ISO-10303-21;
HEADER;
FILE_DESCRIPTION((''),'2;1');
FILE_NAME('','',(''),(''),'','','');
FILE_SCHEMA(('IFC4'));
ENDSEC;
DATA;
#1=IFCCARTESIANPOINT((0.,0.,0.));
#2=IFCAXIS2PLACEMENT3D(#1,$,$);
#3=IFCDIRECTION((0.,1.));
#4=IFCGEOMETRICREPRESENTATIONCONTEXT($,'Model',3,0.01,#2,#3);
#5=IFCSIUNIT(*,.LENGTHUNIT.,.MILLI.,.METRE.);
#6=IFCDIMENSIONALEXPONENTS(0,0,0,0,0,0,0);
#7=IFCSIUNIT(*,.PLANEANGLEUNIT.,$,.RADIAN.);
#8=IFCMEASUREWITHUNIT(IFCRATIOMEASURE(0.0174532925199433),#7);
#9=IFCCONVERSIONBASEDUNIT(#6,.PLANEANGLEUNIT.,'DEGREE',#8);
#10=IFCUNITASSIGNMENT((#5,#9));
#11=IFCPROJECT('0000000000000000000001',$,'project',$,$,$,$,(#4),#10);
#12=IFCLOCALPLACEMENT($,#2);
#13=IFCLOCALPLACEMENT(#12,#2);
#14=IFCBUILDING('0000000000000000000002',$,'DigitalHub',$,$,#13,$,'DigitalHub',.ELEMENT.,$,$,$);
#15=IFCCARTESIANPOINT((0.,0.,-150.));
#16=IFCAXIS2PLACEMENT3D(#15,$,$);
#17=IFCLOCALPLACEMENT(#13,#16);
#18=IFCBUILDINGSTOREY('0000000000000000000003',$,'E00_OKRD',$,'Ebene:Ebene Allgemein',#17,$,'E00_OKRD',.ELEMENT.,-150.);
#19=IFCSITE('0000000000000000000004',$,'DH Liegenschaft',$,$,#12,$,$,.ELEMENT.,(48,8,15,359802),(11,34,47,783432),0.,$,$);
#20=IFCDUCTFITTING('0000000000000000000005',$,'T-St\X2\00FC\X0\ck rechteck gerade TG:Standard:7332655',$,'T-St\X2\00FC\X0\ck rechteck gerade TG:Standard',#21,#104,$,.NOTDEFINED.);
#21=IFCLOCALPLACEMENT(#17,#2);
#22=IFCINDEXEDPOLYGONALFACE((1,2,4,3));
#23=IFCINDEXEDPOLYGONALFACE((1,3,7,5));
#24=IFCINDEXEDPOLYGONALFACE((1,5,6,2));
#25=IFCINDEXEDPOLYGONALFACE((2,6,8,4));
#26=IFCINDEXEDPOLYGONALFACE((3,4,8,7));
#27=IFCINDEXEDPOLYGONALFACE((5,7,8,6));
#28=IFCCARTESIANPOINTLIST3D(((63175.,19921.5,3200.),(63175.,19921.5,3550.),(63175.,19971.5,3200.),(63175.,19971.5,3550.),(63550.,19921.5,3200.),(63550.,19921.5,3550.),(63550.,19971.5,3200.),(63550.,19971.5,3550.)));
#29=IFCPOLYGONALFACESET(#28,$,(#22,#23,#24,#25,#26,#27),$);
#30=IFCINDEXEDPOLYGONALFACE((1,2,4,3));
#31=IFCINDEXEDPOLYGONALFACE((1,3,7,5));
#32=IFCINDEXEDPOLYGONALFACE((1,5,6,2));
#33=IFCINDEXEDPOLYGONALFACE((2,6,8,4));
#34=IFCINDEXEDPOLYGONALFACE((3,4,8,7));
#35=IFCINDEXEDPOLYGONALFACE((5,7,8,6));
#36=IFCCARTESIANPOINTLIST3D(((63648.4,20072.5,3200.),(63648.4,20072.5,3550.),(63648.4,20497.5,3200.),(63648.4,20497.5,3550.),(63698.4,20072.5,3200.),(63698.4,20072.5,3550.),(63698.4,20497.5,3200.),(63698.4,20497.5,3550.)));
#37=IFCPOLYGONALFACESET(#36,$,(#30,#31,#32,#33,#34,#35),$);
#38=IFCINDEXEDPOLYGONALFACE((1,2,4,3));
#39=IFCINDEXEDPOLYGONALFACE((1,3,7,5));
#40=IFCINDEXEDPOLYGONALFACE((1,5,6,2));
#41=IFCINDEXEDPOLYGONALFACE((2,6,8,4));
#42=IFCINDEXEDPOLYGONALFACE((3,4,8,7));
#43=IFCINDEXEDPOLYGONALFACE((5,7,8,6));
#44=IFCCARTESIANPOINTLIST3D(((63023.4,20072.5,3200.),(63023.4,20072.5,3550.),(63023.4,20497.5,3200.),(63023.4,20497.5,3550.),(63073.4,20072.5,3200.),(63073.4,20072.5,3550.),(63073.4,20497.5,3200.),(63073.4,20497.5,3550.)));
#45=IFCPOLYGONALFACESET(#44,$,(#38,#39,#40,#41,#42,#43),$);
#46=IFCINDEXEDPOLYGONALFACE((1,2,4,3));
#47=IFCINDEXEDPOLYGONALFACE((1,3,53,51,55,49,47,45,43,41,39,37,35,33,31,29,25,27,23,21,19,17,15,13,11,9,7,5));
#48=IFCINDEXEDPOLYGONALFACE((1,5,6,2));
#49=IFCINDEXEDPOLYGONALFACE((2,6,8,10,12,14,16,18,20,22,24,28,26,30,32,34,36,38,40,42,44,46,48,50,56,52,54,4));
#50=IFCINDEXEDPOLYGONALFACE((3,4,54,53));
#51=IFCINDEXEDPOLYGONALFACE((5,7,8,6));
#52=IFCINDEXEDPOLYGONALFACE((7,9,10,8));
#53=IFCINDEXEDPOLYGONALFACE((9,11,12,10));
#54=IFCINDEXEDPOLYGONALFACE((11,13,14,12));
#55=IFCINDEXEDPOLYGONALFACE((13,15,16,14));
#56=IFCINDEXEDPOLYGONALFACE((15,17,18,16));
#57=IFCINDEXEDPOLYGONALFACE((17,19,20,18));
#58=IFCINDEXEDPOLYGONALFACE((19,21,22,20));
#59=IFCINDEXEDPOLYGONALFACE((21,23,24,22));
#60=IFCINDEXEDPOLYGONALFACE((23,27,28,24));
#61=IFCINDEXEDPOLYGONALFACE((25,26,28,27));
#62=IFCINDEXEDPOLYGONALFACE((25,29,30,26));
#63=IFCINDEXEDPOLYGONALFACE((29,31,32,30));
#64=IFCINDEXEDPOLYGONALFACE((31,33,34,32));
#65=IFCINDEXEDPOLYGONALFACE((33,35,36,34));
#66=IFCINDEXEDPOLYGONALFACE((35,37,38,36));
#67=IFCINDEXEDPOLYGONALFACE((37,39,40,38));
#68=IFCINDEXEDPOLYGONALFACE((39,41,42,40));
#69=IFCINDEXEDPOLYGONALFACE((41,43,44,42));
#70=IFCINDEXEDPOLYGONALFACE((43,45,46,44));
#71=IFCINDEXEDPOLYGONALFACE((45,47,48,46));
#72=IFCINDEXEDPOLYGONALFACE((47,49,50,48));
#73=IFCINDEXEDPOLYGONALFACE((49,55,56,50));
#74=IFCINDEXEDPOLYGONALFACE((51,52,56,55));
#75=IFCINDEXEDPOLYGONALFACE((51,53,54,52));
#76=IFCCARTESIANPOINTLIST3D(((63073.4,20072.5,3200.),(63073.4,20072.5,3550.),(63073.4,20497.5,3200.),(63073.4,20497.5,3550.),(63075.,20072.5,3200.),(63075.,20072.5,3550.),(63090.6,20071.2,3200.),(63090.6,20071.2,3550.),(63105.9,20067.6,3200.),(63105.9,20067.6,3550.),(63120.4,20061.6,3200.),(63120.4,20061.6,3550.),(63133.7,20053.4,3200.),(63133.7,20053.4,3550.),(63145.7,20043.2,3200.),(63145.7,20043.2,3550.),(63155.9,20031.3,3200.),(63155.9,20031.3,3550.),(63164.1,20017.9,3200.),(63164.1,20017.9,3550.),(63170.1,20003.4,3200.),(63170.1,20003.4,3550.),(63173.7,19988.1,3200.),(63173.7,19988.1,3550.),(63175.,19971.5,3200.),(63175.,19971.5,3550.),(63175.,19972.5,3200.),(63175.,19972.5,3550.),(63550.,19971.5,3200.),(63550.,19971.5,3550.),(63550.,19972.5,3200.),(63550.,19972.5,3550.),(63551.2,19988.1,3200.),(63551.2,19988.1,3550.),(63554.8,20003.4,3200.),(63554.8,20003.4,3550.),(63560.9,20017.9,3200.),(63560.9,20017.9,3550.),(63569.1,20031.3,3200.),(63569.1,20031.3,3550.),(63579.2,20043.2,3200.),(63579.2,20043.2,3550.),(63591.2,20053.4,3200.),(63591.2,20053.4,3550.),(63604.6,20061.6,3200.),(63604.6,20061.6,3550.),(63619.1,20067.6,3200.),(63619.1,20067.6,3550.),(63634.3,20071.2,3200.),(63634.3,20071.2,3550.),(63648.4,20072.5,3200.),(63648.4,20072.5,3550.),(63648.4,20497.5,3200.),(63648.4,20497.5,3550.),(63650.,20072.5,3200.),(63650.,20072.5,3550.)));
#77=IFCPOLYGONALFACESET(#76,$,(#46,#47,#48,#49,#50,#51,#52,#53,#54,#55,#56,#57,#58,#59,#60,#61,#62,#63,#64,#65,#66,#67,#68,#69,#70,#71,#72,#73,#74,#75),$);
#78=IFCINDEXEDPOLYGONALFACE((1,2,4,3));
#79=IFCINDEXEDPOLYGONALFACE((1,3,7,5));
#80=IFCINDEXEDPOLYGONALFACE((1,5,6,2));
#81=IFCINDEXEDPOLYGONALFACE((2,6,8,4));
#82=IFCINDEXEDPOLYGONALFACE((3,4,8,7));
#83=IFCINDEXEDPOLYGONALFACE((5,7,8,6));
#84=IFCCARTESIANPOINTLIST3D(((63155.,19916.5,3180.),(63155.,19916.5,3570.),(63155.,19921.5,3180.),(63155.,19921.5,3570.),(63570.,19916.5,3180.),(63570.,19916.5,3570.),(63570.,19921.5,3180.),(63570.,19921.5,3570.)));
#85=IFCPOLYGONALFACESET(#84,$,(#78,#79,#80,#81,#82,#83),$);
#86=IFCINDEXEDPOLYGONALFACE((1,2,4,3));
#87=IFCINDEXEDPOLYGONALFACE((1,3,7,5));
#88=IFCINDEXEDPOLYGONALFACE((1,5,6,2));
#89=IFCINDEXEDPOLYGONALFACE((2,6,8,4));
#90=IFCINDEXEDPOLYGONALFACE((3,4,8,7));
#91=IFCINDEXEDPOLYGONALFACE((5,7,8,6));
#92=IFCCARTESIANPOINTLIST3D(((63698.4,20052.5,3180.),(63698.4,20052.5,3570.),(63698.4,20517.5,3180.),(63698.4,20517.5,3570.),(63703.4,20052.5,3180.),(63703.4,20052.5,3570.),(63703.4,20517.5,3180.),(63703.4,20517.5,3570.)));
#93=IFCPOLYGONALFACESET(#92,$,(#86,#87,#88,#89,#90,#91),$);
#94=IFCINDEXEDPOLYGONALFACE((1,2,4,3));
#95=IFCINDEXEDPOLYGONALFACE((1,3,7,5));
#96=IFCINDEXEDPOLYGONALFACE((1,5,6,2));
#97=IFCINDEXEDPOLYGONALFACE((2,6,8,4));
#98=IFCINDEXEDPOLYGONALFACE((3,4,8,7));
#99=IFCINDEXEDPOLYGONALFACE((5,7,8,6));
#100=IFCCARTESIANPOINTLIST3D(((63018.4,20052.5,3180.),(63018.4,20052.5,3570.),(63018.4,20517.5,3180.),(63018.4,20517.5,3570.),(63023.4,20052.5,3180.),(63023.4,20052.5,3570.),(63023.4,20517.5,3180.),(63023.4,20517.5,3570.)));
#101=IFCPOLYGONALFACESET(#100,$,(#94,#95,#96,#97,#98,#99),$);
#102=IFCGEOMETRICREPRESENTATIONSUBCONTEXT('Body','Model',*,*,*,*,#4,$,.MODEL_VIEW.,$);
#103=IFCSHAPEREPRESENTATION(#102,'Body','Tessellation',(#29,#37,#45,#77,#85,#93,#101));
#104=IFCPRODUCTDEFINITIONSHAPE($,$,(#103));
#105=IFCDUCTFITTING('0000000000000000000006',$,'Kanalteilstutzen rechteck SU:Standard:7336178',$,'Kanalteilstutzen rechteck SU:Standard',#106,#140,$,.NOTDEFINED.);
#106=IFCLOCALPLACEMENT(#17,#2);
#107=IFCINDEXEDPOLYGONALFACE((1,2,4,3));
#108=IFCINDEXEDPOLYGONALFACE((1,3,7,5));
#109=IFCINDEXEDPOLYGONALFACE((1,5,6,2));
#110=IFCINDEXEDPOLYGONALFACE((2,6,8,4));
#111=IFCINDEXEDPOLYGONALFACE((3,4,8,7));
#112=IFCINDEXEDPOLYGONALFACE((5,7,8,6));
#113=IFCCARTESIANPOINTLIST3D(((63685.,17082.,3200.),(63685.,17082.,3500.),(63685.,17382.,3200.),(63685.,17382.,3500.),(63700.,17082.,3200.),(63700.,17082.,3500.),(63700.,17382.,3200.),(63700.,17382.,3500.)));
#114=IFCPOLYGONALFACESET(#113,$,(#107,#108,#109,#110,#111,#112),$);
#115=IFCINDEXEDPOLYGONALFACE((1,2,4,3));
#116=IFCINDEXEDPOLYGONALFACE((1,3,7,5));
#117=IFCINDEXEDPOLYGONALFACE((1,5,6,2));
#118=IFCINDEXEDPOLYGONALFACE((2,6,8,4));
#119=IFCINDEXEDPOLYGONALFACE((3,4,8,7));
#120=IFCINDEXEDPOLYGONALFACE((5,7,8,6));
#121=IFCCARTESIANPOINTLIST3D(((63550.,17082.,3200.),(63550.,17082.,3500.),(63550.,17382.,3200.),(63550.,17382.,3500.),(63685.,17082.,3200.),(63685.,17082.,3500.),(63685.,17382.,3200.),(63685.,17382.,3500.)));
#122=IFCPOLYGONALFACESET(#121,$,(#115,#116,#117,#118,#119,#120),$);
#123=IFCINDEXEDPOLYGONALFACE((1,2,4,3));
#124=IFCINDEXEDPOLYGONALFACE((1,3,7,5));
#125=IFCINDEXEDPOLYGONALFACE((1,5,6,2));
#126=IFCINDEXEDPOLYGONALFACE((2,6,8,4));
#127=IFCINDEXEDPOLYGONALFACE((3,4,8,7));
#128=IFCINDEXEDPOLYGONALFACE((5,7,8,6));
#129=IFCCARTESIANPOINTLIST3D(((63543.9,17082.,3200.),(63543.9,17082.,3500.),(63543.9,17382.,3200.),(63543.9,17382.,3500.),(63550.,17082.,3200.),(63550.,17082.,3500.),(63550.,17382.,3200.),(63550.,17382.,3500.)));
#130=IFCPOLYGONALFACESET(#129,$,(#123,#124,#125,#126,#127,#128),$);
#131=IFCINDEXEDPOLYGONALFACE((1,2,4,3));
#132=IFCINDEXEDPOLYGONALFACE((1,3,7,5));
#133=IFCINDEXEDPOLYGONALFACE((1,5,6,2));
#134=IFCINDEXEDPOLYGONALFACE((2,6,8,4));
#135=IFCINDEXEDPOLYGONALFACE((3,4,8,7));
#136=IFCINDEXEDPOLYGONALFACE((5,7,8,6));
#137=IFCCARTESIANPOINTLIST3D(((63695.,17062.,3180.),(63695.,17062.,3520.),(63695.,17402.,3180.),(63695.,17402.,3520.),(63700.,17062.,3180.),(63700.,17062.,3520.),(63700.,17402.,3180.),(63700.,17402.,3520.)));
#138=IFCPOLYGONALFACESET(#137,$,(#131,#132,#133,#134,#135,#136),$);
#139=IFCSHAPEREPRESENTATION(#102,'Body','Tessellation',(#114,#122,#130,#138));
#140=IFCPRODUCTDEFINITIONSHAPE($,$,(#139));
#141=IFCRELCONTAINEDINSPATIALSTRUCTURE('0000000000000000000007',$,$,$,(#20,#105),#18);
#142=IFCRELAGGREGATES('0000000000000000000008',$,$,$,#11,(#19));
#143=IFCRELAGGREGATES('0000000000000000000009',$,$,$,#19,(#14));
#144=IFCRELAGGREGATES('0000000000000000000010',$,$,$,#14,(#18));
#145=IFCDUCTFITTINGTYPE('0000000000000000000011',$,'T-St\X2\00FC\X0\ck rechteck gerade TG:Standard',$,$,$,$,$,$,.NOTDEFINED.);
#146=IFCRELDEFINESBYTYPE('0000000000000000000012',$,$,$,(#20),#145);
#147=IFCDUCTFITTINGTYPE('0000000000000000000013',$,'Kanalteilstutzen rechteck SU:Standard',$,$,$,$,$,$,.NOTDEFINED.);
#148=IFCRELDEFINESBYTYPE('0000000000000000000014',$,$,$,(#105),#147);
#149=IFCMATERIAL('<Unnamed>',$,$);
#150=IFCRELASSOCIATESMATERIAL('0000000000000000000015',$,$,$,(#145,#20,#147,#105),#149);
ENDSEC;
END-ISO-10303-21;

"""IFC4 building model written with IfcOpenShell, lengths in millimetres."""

from ifc_helpers import new_model, entity, si_unit, converted_unit, direction, frame, origin, place, context, subcontext, project, spatial, indexed_curve, outline, extrude, source, transform, mapped, material, type_object, type_shapes, element, save


model = new_model("IFC4")

# Units and contexts
model_context = context("Model", 3, precision=0.01, world=origin(), true_north=direction((0.0, 1.0)))
body_context = subcontext(model_context, "Body", "Model", "MODEL_VIEW")
ifc_project = project(units=[si_unit("LENGTHUNIT", "METRE", prefix="MILLI"), converted_unit("PLANEANGLEUNIT", "DEGREE", entity("IfcRatioMeasure", 0.0174532925199433), si_unit("PLANEANGLEUNIT", "RADIAN"), dimensions=[0, 0, 0, 0, 0, 0, 0])], contexts=[model_context])

# Site, building, storey
site_placement = place(None, origin())
site = spatial("IfcSite", under=ifc_project, at=site_placement, Name="DH Liegenschaft", CompositionType="ELEMENT", RefLatitude=(48, 8, 15, 359802), RefLongitude=(11, 34, 47, 783432), RefElevation=0.0)
building_placement = place(site_placement, origin())
building = spatial("IfcBuilding", under=site, at=building_placement, Name="DigitalHub", LongName="DigitalHub", CompositionType="ELEMENT")
storey_placement = place(building_placement, frame((0.0, 0.0, -150.0)))
storey = spatial("IfcBuildingStorey", under=building, at=storey_placement, Name="E00_OKRD", ObjectType="Ebene:Ebene Allgemein", LongName="E00_OKRD", CompositionType="ELEMENT", Elevation=-150.0)

# Shared definitions
ifc_material_1 = material(Name="<Unnamed>")

# Duct fittings
duct_fitting_type_1 = type_object("IfcDuctFittingType", Name="T-Stück rechteck gerade TG:Standard", PredefinedType="NOTDEFINED", material=ifc_material_1)
shared_shape_1 = source(origin(), body_context, "Body", "SweptSolid", [
    extrude(outline(indexed_curve([(-25.0, -187.5), (25.0, -187.5), (25.0, 187.5), (-25.0, 187.5), (-25.0, -187.5)], self_intersect=False)), frame((0.0, -338.5, -175.0), z_axis=(0.0, 0.0, 1.0), x_axis=(0.0, -1.0, 0.0)), (0.0, 0.0, 1.0), 350.0),
    extrude(outline(indexed_curve([(-25.0, -212.5), (25.0, -212.5), (25.0, 212.5), (-25.0, 212.5), (-25.0, -212.5)], self_intersect=False)), frame((310.9, 0.0, -175.0), z_axis=(0.0, 0.0, 1.0), x_axis=(-1.0, 0.0, 0.0)), (0.0, 0.0, 1.0), 350.0),
    extrude(outline(indexed_curve([(-25.0, -212.5), (25.0, -212.5), (25.0, 212.5), (-25.0, 212.5), (-25.0, -212.5)], self_intersect=False)), frame((-314.1, 0.0, -175.0)), (0.0, 0.0, 1.0), 350.0),
    extrude(outline(indexed_curve([(-288.1, -44.8), (-272.5, -46.0), (-257.2, -49.7), (-242.7, -55.7), (-229.4, -63.9), (-217.4, -74.1), (-207.2, -86.0), (-199.0, -99.4), (-193.0, -113.9), (-189.4, -129.2), (-188.1, -144.8), (-188.1, -145.8), (186.9, -145.8), (186.9, -144.8), (188.1, -129.2), (191.8, -113.9), (197.8, -99.4), (206.0, -86.0), (216.1, -74.1), (228.1, -63.9), (241.5, -55.7), (256.0, -49.7), (271.2, -46.0), (286.9, -44.8), (288.5, -44.8), (288.5, 380.2), (-286.5, 380.2), (-286.5, -44.8), (-288.1, -44.8)], self_intersect=False)), frame((-0.6, -167.7, -175.0), z_axis=(0.0, 0.0, -1.0), x_axis=(-1.0, 0.0, 0.0)), (0.0, 0.0, -1.0), 350.0),
    extrude(outline(indexed_curve([(-2.5, -207.5), (2.5, -207.5), (2.5, 207.5), (-2.5, 207.5), (-2.5, -207.5)], self_intersect=False)), frame((0.0, -366.0, -195.0), z_axis=(0.0, 0.0, 1.0), x_axis=(0.0, 1.0, 0.0)), (0.0, 0.0, 1.0), 390.0),
    extrude(outline(indexed_curve([(-2.5, -232.5), (2.5, -232.5), (2.5, 232.5), (-2.5, 232.5), (-2.5, -232.5)], self_intersect=False)), frame((338.4, 0.0, -195.0), z_axis=(0.0, 0.0, 1.0), x_axis=(-1.0, 0.0, 0.0)), (0.0, 0.0, 1.0), 390.0),
    extrude(outline(indexed_curve([(-2.5, -232.5), (2.5, -232.5), (2.5, 232.5), (-2.5, 232.5), (-2.5, -232.5)], self_intersect=False)), frame((-341.6, 0.0, -195.0), z_axis=(0.0, 0.0, 1.0), x_axis=(-1.0, 0.0, 0.0)), (0.0, 0.0, 1.0), 390.0),
])
type_shapes(duct_fitting_type_1, [shared_shape_1])
duct_fitting_1_placement = place(storey_placement, frame((63362.5, 20285.0, 3375.0)))
element("IfcDuctFitting", 1, at=duct_fitting_1_placement, inside=storey, type_object=duct_fitting_type_1, material=ifc_material_1, Name="T-Stück rechteck gerade TG:Standard:7332655", ObjectType="T-Stück rechteck gerade TG:Standard", PredefinedType="NOTDEFINED", context=body_context, shape_type="MappedRepresentation", body=[
    mapped(shared_shape_1, transform((0.0, 0.0, 0.0), scale=1.0)),
])
duct_fitting_type_2 = type_object("IfcDuctFittingType", Name="Kanalteilstutzen rechteck SU:Standard", PredefinedType="NOTDEFINED", material=ifc_material_1)
shared_shape_2 = source(origin(), body_context, "Body", "SweptSolid", [
    extrude(outline(indexed_curve([(-150.0, -7.5), (150.0, -7.5), (150.0, 7.5), (-150.0, 7.5), (-150.0, -7.5)], self_intersect=False)), frame((142.5, 0.0, -150.0), z_axis=(0.0, 0.0, 1.0), x_axis=(0.0, -1.0, 0.0)), (0.0, 0.0, 1.0), 300.0),
    extrude(outline(indexed_curve([(-150.0, -67.5), (150.0, -67.5), (150.0, 67.5), (-150.0, 67.5), (-150.0, -67.5)], self_intersect=False)), frame((67.5, 0.0, -150.0), z_axis=(0.0, 0.0, 1.0), x_axis=(0.0, -1.0, 0.0)), (0.0, 0.0, 1.0), 300.0),
    extrude(outline(indexed_curve([(-150.0, -3.0), (150.0, -3.0), (150.0, 3.0), (-150.0, 3.0), (-150.0, -3.0)], self_intersect=False)), frame((-3.0, 0.0, -150.0), z_axis=(0.0, 0.0, 1.0), x_axis=(0.0, -1.0, 0.0)), (0.0, 0.0, 1.0), 300.0),
    extrude(outline(indexed_curve([(-170.0, -2.5), (170.0, -2.5), (170.0, 2.5), (-170.0, 2.5), (-170.0, -2.5)], self_intersect=False)), frame((147.5, 0.0, -170.0), z_axis=(0.0, 0.0, 1.0), x_axis=(0.0, -1.0, 0.0)), (0.0, 0.0, 1.0), 340.0),
])
type_shapes(duct_fitting_type_2, [shared_shape_2])
duct_fitting_2_placement = place(storey_placement, frame((63550.0, 17232.0, 3350.0), z_axis=(0.0, 0.0, -1.0), x_axis=(1.0, 0.0, 0.0)))
element("IfcDuctFitting", 2, at=duct_fitting_2_placement, inside=storey, type_object=duct_fitting_type_2, material=ifc_material_1, Name="Kanalteilstutzen rechteck SU:Standard:7336178", ObjectType="Kanalteilstutzen rechteck SU:Standard", PredefinedType="NOTDEFINED", context=body_context, shape_type="MappedRepresentation", body=[
    mapped(shared_shape_2, transform((0.0, 0.0, 0.0), scale=1.0)),
])

save(model, "model.ifc")
